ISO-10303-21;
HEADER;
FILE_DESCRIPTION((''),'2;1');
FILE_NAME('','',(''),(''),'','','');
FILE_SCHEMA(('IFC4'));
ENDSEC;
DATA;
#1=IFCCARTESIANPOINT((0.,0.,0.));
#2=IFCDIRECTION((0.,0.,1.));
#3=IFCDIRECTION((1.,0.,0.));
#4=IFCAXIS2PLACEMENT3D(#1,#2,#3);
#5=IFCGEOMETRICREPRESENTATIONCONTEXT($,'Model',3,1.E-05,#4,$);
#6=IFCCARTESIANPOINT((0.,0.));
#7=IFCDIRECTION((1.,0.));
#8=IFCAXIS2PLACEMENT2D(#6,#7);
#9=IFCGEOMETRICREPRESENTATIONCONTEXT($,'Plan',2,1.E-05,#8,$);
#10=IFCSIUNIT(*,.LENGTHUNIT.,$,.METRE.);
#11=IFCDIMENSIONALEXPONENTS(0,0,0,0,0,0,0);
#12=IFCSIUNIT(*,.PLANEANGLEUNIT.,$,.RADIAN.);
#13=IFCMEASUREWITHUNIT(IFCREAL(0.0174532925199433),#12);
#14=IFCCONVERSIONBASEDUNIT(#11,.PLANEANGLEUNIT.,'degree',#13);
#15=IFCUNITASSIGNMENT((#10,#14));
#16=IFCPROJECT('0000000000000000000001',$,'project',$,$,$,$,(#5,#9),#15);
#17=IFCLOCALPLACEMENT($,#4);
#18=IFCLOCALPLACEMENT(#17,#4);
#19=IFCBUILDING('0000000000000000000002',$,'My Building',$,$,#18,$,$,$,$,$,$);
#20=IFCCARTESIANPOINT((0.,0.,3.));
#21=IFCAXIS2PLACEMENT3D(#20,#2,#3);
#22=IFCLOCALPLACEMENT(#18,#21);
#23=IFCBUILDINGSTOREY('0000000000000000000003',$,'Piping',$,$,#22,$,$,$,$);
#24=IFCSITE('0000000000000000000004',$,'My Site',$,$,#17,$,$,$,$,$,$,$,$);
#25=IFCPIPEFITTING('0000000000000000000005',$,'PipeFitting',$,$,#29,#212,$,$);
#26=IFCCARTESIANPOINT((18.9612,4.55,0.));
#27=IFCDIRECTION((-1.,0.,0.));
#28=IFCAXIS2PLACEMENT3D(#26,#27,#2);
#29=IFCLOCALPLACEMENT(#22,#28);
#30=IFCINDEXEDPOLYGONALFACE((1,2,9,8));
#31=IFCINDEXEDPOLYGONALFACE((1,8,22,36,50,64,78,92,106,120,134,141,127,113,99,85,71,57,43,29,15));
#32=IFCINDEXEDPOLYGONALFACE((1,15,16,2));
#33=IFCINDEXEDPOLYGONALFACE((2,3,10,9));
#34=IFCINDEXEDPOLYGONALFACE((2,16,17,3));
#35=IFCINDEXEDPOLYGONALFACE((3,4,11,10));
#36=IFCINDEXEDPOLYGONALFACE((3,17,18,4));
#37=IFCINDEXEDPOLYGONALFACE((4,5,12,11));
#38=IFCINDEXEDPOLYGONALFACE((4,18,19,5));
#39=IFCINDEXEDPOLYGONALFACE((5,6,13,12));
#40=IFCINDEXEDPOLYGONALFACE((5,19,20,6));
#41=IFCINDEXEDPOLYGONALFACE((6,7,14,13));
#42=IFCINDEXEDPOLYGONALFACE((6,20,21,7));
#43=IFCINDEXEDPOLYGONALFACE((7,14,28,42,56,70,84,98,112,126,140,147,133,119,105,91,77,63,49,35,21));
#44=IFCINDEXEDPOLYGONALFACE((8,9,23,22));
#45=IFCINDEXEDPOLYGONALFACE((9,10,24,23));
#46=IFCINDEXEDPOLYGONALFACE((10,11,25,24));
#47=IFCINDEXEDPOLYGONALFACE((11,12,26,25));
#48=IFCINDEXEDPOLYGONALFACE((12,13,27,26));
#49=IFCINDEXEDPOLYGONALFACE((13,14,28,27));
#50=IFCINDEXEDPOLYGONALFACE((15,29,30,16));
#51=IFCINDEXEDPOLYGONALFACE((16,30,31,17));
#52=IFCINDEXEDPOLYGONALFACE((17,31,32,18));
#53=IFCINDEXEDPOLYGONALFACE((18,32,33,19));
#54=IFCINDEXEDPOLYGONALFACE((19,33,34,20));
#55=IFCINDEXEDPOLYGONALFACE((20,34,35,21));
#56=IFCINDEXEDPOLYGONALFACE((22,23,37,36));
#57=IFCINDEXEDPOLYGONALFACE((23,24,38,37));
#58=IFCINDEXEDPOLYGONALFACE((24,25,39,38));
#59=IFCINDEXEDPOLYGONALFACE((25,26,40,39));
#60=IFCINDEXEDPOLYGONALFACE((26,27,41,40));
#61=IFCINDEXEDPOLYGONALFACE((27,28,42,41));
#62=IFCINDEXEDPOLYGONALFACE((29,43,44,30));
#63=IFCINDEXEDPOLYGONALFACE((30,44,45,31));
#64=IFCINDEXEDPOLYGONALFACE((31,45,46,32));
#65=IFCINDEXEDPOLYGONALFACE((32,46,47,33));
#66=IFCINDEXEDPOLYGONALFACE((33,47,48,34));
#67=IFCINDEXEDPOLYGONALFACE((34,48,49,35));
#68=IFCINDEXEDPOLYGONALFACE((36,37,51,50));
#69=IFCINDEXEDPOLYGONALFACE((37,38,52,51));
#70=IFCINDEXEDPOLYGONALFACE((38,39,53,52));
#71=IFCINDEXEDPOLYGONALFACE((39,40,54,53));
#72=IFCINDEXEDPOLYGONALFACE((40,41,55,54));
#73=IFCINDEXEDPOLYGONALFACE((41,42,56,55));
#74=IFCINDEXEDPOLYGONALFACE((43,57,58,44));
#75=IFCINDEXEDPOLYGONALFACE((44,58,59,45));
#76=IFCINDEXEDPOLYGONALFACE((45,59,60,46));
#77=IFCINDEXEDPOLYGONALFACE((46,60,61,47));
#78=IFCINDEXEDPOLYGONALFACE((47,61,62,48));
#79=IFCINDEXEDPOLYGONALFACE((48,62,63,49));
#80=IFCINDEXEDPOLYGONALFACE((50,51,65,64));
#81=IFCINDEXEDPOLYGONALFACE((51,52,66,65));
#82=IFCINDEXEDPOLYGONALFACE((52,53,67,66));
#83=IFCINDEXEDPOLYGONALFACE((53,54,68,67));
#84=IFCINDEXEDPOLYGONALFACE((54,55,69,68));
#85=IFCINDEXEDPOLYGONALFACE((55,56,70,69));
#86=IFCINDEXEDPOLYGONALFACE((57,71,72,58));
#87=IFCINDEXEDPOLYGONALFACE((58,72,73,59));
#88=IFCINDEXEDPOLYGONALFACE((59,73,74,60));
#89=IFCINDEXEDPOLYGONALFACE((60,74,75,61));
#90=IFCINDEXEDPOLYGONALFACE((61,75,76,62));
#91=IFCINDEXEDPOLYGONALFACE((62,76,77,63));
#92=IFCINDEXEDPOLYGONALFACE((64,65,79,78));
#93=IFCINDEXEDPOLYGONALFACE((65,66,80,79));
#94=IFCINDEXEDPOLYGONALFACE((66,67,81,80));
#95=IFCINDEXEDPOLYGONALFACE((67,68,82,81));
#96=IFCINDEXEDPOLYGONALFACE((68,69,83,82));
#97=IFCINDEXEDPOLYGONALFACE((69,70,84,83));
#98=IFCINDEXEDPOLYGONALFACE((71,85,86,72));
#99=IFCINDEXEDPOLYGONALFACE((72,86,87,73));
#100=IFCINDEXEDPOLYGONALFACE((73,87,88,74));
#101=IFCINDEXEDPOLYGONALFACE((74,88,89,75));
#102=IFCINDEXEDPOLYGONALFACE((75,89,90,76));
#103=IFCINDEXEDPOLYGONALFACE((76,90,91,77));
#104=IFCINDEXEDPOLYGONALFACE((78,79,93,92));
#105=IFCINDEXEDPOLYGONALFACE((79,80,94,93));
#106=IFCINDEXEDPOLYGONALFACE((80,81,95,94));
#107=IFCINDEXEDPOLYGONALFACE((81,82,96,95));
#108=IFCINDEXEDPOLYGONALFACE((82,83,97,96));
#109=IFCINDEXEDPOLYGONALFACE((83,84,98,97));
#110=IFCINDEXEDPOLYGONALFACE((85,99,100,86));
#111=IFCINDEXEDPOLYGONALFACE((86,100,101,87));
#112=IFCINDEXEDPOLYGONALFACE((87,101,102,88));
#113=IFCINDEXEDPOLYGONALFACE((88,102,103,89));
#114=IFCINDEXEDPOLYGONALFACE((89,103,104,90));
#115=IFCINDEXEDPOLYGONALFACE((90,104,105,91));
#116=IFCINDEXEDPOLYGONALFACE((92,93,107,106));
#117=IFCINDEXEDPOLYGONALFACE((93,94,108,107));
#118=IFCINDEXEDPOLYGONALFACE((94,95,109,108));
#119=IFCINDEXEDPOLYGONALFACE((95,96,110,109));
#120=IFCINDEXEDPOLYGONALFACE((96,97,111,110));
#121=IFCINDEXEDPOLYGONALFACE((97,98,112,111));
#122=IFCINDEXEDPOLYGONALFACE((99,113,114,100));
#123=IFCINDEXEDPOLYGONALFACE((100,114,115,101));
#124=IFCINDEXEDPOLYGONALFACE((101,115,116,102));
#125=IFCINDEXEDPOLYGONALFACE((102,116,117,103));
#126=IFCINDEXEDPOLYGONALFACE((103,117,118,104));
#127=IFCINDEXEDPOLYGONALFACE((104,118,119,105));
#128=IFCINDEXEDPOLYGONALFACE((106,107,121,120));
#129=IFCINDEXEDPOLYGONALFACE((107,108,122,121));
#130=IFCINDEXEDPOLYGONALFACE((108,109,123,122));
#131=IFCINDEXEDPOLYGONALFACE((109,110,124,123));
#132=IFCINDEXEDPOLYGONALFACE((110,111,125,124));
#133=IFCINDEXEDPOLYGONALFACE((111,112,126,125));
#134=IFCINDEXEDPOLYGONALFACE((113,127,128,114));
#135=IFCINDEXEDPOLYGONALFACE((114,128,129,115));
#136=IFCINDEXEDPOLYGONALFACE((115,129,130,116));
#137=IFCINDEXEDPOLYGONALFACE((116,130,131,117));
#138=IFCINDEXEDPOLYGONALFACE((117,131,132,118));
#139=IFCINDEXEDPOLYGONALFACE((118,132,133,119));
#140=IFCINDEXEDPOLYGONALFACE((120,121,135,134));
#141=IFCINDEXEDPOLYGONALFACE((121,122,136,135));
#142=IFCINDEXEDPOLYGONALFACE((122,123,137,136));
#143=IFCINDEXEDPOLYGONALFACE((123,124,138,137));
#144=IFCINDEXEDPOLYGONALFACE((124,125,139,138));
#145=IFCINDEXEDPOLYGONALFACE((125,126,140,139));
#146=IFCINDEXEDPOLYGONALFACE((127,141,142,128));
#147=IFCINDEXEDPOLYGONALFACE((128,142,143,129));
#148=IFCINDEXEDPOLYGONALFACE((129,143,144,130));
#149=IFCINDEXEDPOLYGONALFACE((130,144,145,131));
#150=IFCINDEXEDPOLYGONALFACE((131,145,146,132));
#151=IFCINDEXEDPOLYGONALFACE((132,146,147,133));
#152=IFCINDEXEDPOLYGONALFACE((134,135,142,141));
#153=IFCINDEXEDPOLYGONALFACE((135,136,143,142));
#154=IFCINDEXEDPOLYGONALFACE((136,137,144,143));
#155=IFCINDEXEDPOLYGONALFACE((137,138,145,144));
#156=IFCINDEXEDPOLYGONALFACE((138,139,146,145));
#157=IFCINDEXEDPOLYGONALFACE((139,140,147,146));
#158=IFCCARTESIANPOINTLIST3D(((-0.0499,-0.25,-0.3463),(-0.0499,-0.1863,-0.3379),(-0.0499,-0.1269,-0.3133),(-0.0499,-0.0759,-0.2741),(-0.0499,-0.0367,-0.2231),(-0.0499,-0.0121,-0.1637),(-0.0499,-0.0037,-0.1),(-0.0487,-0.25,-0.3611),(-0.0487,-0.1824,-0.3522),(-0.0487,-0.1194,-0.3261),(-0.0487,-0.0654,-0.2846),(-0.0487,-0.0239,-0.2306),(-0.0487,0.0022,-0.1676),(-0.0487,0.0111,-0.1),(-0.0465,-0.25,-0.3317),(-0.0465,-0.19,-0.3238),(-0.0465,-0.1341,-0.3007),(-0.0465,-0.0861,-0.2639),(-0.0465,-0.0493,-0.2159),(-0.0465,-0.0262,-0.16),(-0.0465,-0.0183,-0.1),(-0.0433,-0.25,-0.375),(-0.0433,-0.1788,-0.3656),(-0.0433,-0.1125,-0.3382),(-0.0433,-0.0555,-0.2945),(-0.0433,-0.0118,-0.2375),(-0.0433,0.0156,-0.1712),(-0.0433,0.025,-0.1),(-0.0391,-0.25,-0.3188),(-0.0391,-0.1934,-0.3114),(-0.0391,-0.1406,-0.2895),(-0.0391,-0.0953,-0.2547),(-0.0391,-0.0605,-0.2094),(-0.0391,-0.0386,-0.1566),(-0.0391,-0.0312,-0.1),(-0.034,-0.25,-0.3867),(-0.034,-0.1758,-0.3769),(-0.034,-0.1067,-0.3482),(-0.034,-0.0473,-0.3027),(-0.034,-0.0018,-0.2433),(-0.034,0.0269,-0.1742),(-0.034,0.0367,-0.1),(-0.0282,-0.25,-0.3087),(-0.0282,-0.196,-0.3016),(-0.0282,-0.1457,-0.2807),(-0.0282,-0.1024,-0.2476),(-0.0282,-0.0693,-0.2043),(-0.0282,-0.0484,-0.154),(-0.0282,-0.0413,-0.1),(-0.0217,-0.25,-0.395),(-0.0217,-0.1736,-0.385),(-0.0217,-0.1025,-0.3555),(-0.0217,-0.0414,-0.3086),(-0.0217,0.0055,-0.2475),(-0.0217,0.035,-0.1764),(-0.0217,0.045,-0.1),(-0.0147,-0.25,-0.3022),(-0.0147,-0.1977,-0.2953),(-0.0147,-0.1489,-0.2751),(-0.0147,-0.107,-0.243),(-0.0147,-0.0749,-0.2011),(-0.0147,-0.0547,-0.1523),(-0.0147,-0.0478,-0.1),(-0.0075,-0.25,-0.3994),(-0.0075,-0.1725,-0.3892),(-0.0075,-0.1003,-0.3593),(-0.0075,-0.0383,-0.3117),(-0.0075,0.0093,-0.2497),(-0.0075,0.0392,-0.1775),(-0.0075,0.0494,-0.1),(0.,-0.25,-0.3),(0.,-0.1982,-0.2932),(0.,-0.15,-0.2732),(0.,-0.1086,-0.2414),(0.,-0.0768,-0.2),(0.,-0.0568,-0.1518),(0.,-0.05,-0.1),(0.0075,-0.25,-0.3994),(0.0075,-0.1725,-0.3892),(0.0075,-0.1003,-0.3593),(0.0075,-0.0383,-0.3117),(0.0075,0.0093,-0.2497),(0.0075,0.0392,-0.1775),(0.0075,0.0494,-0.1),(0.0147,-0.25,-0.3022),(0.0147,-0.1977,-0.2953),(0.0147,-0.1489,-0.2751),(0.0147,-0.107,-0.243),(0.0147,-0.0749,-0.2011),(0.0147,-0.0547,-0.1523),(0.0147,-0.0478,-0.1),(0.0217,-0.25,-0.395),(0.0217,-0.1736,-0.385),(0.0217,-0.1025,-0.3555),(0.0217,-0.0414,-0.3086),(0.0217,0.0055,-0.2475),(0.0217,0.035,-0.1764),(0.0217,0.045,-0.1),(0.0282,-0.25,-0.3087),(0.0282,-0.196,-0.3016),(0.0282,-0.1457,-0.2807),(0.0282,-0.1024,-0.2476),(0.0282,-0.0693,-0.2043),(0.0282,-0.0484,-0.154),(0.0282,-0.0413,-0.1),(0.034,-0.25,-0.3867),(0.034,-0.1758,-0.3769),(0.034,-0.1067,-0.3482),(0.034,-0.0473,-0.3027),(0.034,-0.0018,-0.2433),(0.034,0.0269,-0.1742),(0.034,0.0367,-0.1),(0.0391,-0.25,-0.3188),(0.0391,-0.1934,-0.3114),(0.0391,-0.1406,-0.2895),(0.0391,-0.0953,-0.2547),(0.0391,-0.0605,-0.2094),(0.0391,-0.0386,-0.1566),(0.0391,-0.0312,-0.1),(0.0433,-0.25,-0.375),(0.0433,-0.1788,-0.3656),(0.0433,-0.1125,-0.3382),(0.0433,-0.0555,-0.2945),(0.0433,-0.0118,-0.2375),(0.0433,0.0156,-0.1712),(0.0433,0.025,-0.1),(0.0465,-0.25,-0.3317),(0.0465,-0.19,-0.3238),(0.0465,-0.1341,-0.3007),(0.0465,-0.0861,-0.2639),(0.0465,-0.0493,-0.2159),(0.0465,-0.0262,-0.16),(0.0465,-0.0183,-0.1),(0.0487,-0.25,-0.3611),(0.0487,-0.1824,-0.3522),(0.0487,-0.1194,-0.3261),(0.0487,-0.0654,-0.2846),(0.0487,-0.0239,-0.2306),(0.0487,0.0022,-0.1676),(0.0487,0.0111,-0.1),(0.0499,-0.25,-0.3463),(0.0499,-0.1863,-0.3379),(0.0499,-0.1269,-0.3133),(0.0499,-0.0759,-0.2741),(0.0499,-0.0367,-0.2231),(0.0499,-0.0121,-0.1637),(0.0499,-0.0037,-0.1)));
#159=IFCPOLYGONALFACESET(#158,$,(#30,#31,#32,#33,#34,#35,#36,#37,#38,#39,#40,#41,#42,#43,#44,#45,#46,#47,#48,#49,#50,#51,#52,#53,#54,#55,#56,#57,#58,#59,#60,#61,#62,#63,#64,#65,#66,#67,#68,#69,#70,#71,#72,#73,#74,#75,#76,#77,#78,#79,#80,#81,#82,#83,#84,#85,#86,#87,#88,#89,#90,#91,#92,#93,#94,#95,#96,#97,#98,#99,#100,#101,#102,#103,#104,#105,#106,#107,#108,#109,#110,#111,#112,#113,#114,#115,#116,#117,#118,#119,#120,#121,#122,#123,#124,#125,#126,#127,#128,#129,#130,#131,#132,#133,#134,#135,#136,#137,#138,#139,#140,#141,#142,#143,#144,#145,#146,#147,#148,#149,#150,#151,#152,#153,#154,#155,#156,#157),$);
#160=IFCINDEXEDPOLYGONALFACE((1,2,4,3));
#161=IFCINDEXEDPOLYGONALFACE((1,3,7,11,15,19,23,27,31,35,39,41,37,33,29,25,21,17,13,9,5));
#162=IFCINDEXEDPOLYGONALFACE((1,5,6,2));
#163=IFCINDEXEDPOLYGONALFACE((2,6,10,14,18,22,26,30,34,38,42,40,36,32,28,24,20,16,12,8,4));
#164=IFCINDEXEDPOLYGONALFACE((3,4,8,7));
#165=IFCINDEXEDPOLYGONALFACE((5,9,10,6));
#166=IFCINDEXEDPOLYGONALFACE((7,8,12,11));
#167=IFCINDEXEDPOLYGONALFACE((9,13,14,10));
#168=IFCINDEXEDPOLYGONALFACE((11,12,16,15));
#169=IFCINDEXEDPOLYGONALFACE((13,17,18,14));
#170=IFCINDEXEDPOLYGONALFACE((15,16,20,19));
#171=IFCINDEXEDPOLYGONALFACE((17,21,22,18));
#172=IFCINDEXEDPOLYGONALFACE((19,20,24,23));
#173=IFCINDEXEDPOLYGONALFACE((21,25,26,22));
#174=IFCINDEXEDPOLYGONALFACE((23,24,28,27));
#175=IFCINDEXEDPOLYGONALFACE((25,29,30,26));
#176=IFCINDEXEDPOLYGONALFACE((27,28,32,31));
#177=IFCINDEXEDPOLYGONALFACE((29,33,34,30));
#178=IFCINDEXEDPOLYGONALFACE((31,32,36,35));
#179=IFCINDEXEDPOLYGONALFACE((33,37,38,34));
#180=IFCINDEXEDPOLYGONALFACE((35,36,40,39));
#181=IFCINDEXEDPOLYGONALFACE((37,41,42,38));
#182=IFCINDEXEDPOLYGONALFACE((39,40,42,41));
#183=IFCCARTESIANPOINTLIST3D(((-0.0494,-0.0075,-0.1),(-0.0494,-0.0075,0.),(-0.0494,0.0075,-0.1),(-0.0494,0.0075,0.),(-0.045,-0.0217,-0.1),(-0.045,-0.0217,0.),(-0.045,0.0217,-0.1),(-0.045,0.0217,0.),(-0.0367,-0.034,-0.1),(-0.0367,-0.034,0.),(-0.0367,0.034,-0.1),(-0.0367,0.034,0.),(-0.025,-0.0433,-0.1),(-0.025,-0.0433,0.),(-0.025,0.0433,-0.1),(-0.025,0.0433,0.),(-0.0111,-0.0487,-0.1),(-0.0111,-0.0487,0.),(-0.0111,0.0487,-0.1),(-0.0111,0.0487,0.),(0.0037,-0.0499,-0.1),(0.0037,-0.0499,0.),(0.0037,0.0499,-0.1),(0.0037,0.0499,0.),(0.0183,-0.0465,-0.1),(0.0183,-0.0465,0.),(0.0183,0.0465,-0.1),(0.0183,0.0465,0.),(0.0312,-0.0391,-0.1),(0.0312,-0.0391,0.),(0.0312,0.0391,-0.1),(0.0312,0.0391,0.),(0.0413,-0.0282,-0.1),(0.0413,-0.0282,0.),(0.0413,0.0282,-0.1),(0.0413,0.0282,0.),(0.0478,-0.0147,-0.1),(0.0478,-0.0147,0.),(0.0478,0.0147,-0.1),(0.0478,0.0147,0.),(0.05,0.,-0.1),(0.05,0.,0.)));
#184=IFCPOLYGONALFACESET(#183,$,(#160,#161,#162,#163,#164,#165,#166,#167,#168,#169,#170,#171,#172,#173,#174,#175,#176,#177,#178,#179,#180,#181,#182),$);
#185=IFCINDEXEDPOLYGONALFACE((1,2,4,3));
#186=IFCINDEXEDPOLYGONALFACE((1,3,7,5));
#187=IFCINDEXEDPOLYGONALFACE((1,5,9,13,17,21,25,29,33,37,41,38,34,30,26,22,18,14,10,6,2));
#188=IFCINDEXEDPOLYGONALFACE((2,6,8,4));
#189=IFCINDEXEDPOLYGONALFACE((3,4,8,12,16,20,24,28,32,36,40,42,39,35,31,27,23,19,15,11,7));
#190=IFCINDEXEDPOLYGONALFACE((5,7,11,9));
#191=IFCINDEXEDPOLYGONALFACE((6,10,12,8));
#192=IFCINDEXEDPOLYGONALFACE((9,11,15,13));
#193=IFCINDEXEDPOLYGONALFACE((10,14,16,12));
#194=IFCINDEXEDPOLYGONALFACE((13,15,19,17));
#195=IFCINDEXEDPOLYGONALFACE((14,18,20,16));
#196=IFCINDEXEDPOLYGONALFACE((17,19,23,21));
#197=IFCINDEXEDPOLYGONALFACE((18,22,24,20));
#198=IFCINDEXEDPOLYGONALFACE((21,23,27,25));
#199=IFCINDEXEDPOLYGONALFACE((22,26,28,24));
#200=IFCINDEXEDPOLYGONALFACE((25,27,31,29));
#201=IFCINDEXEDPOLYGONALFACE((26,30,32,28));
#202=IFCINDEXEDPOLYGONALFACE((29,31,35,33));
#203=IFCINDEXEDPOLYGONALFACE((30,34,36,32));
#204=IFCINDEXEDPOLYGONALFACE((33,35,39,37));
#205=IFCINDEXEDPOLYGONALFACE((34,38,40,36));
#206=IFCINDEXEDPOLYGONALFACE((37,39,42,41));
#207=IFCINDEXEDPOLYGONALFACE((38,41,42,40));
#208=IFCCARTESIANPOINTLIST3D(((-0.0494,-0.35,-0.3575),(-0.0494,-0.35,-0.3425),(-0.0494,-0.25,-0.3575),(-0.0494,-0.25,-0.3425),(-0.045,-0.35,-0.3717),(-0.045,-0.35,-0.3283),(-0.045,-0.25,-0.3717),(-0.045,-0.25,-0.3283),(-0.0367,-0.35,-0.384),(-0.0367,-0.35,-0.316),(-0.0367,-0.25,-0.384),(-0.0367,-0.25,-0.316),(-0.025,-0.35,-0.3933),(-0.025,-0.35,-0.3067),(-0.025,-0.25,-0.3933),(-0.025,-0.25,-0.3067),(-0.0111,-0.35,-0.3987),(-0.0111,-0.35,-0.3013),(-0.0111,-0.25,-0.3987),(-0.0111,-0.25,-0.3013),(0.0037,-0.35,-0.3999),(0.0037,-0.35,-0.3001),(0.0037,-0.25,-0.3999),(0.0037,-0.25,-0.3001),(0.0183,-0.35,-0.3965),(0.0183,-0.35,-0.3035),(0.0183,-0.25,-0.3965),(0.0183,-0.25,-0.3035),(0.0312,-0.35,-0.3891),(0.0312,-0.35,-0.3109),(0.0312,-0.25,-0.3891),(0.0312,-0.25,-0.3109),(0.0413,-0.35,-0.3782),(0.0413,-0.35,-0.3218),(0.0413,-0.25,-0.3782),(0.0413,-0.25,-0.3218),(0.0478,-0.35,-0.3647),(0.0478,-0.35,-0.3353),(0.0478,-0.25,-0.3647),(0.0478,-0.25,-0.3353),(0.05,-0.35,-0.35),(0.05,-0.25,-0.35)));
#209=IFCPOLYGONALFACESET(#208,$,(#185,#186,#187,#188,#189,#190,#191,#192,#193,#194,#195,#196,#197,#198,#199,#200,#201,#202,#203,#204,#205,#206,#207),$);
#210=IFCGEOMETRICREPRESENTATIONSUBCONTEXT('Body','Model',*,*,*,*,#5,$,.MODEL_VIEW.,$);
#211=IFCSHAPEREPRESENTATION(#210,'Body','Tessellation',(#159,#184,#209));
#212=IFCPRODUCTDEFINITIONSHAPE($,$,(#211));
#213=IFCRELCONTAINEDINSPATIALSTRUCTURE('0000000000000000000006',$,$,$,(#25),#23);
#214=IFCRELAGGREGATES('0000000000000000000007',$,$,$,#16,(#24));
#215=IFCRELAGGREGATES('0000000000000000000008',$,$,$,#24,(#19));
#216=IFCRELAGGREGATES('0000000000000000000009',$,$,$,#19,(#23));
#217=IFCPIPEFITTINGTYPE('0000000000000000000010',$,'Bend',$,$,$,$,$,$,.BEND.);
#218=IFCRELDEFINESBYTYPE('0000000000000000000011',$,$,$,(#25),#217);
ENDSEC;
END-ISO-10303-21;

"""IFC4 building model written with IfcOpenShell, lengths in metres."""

from ifc_helpers import new_model, entity, si_unit, converted_unit, frame, origin_with_axes, origin_2d_with_axis, place, context, subcontext, project, spatial, circle, extrude, source, transform, mapped, type_object, type_shapes, element, save


model = new_model("IFC4")

# Units and contexts
model_context = context("Model", 3, precision=1e-05, world=origin_with_axes())
plan_context = context("Plan", 2, precision=1e-05, world=origin_2d_with_axis())
body_context = subcontext(model_context, "Body", "Model", "MODEL_VIEW")
ifc_project = project(units=[si_unit("LENGTHUNIT", "METRE"), converted_unit("PLANEANGLEUNIT", "degree", entity("IfcReal", 0.0174532925199433), si_unit("PLANEANGLEUNIT", "RADIAN"), dimensions=[0, 0, 0, 0, 0, 0, 0])], contexts=[model_context, plan_context])

# Site, building, storey
site_placement = place(None, origin_with_axes())
site = spatial("IfcSite", under=ifc_project, at=site_placement, Name="My Site")
building_placement = place(site_placement, origin_with_axes())
building = spatial("IfcBuilding", under=site, at=building_placement, Name="My Building")
storey_placement = place(building_placement, frame((0.0, 0.0, 3.0), z_axis=(0.0, 0.0, 1.0), x_axis=(1.0, 0.0, 0.0)))
storey = spatial("IfcBuildingStorey", under=building, at=storey_placement, Name="Piping")

# Pipe fitting
pipe_fitting_type = type_object("IfcPipeFittingType", Name="Bend", PredefinedType="BEND")
shared_shape = source(origin_with_axes(), body_context, "Body", "SolidModel", [
    entity("IfcSweptDiskSolid", entity("IfcIndexedPolyCurve", entity("IfcCartesianPointList3D", [[0.0, 0.0, -0.1], [0.0, -0.0732, -0.2768], [0.0, -0.25, -0.35]]), [entity("IfcArcIndex", [1, 2, 3])]), 0.05),
    extrude(circle(Radius=0.05), origin_with_axes(), (0.0, 0.0, -1.0), 0.1),
    extrude(circle(Radius=0.05), frame((0.0, -0.25, -0.35), z_axis=(0.0, -1.0, 0.0), x_axis=(1.0, 0.0, 0.0)), (0.0, 0.0, 1.0), 0.1),
])
type_shapes(pipe_fitting_type, [shared_shape])
for number, where, z_axis, x_axis, name in (
    (1, (18.9612, 4.55, 0.0), (-1.0, 0.0, 0.0), (0.0, 0.0, 1.0), "PipeFitting"),
):
    element("IfcPipeFitting", number, at=place(storey_placement, frame(where, z_axis=z_axis, x_axis=x_axis)), inside=storey, type_object=pipe_fitting_type, Name=name, context=body_context, shape_type="MappedRepresentation", body=[
        mapped(shared_shape, transform((0.0, 0.0, 0.0), x_axis=(1.0, 0.0, 0.0), y_axis=(0.0, 1.0, 0.0), z_axis=(0.0, 0.0, 1.0), scale=1.0)),
    ])

save(model, "model.ifc")
